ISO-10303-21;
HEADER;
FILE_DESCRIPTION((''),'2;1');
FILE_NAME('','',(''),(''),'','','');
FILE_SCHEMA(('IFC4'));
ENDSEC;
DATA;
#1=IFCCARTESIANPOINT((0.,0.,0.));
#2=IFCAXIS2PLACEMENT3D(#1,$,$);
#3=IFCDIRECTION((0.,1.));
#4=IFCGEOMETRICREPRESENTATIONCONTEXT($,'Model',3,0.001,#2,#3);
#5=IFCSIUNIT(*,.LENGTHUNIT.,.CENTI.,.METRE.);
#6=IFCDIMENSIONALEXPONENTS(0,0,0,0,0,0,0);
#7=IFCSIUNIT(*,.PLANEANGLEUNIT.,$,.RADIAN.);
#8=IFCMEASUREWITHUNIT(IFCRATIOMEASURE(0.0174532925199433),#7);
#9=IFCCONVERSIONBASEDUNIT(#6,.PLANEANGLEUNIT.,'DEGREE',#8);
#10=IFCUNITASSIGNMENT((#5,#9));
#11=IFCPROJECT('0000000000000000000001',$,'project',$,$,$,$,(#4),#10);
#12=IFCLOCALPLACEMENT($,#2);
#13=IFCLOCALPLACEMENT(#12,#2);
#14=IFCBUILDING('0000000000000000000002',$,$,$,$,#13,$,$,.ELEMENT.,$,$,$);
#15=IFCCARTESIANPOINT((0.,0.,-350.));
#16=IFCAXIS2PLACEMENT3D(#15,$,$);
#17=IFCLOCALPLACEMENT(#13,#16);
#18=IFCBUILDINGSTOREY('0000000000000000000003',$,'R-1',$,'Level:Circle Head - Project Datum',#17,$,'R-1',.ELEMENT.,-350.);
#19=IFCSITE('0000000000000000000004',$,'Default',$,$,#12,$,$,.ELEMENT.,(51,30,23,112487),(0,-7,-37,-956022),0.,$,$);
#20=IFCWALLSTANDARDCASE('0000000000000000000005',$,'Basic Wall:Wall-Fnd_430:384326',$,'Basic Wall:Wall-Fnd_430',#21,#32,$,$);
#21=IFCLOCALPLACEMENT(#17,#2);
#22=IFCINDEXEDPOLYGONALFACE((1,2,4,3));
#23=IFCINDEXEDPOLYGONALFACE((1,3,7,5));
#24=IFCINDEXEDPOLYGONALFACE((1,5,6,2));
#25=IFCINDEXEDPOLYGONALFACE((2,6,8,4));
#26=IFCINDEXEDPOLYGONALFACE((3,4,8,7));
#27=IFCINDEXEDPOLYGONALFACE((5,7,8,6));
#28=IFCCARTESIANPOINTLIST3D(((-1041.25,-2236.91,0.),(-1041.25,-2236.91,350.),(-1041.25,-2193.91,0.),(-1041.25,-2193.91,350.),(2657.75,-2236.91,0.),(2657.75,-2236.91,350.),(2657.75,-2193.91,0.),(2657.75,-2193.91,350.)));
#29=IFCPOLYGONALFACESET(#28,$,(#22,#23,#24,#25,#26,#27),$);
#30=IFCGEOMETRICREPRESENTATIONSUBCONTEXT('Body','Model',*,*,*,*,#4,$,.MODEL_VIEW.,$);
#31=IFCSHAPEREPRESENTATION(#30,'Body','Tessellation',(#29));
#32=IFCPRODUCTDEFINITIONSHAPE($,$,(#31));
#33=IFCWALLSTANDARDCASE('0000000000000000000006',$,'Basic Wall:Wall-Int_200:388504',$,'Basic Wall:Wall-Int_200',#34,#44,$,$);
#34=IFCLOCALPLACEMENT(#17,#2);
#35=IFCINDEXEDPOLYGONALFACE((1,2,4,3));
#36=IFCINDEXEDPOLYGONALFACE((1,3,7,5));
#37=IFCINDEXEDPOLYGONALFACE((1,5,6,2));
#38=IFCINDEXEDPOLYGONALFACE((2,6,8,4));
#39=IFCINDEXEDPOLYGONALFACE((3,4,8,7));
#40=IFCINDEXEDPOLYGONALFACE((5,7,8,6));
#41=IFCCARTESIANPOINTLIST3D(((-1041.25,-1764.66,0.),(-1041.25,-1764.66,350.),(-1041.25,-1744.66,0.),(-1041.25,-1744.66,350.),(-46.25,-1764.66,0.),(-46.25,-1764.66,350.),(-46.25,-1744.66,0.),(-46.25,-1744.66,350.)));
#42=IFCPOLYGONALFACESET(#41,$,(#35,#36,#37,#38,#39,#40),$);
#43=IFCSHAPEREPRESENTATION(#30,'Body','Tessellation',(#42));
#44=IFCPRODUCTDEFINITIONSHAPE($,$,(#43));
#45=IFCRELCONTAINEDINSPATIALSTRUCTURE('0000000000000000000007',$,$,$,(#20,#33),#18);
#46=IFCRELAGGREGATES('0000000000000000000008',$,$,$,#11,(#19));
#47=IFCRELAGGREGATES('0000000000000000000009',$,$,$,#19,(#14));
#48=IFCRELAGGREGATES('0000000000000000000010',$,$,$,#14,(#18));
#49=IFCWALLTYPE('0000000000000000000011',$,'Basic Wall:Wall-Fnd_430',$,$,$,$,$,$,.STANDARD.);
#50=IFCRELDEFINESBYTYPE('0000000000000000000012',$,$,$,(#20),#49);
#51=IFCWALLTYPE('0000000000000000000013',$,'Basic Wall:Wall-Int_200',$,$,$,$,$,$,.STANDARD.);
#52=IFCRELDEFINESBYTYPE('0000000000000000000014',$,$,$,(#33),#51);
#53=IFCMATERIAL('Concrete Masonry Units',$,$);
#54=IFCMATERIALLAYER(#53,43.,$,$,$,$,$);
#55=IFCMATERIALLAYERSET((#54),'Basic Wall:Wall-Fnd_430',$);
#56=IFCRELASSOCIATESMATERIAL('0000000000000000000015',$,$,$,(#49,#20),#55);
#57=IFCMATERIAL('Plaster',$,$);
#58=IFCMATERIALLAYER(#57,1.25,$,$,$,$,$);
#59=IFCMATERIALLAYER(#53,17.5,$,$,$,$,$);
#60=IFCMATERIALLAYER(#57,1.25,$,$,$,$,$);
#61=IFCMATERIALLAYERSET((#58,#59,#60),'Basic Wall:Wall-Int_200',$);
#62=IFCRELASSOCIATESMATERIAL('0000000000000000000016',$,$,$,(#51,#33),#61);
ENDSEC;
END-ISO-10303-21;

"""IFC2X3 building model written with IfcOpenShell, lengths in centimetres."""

from ifc_helpers import new_model, entity, si_unit, converted_unit, direction, frame, frame_2d, origin, place, context, subcontext, project, spatial, rectangle, extrude, material, layer, layer_set, layer_usage, type_object, element, save


model = new_model("IFC2X3")

# Units and contexts
model_context = context("Model", 3, precision=0.001, world=origin(), true_north=direction((0.0, 1.0)))
body_context = subcontext(model_context, "Body", "Model", "MODEL_VIEW")
ifc_project = project(units=[si_unit("LENGTHUNIT", "METRE", prefix="CENTI"), converted_unit("PLANEANGLEUNIT", "DEGREE", entity("IfcRatioMeasure", 0.0174532925199433), si_unit("PLANEANGLEUNIT", "RADIAN"), dimensions=[0, 0, 0, 0, 0, 0, 0])], contexts=[model_context])

# Site, building, storey
site_placement = place(None, origin())
site = spatial("IfcSite", under=ifc_project, at=site_placement, Name="Default", CompositionType="ELEMENT", RefLatitude=(51, 30, 23, 112487), RefLongitude=(0, -7, -37, -956022), RefElevation=0.0)
building_placement = place(site_placement, origin())
building = spatial("IfcBuilding", under=site, at=building_placement, CompositionType="ELEMENT")
storey_placement = place(building_placement, frame((0.0, 0.0, -350.0)))
storey = spatial("IfcBuildingStorey", under=building, at=storey_placement, Name="R-1", ObjectType="Level:Circle Head - Project Datum", LongName="R-1", CompositionType="ELEMENT", Elevation=-350.0)

# Walls
ifc_material_1 = material(Name="Concrete Masonry Units")
ifc_layer_1 = layer(ifc_material_1, 43.0)
ifc_layer_set_1 = layer_set([ifc_layer_1], Name="Basic Wall:Wall-Fnd_430")
ifc_layer_usage_1 = layer_usage(ifc_layer_set_1, "AXIS2", "NEGATIVE", 21.5)
wall_type_1 = type_object("IfcWallType", Name="Basic Wall:Wall-Fnd_430", PredefinedType="STANDARD", material=ifc_layer_set_1)
wall_1_placement = place(storey_placement, frame((-1041.25, -2215.41, 0.0)))
element("IfcWallStandardCase", 1, at=wall_1_placement, inside=storey, type_object=wall_type_1, material=ifc_layer_usage_1, Name="Basic Wall:Wall-Fnd_430:384326", ObjectType="Basic Wall:Wall-Fnd_430", context=body_context, shape_type="SweptSolid", body=[
    extrude(rectangle(XDim=3699.0, YDim=43.0, at=frame_2d((1849.5, 0.0), x_axis=(-1.0, 0.0))), origin(), (0.0, 0.0, 1.0), 350.0),
])
ifc_material_2 = material(Name="Plaster")
ifc_layer_2 = layer(ifc_material_2, 1.25)
ifc_layer_3 = layer(ifc_material_1, 17.5)
ifc_layer_4 = layer(ifc_material_2, 1.25)
ifc_layer_set_2 = layer_set([ifc_layer_2, ifc_layer_3, ifc_layer_4], Name="Basic Wall:Wall-Int_200")
ifc_layer_usage_2 = layer_usage(ifc_layer_set_2, "AXIS2", "NEGATIVE", 10.0)
wall_type_2 = type_object("IfcWallType", Name="Basic Wall:Wall-Int_200", PredefinedType="STANDARD", material=ifc_layer_set_2)
wall_2_placement = place(storey_placement, frame((-46.25, -1754.66, 0.0), z_axis=(0.0, 0.0, 1.0), x_axis=(-1.0, 0.0, 0.0)))
element("IfcWallStandardCase", 2, at=wall_2_placement, inside=storey, type_object=wall_type_2, material=ifc_layer_usage_2, Name="Basic Wall:Wall-Int_200:388504", ObjectType="Basic Wall:Wall-Int_200", context=body_context, shape_type="SweptSolid", body=[
    extrude(rectangle(XDim=995.0, YDim=20.0, at=frame_2d((497.5, 0.0), x_axis=(-1.0, 0.0))), origin(), (0.0, 0.0, 1.0), 350.0),
])

save(model, "model.ifc")
